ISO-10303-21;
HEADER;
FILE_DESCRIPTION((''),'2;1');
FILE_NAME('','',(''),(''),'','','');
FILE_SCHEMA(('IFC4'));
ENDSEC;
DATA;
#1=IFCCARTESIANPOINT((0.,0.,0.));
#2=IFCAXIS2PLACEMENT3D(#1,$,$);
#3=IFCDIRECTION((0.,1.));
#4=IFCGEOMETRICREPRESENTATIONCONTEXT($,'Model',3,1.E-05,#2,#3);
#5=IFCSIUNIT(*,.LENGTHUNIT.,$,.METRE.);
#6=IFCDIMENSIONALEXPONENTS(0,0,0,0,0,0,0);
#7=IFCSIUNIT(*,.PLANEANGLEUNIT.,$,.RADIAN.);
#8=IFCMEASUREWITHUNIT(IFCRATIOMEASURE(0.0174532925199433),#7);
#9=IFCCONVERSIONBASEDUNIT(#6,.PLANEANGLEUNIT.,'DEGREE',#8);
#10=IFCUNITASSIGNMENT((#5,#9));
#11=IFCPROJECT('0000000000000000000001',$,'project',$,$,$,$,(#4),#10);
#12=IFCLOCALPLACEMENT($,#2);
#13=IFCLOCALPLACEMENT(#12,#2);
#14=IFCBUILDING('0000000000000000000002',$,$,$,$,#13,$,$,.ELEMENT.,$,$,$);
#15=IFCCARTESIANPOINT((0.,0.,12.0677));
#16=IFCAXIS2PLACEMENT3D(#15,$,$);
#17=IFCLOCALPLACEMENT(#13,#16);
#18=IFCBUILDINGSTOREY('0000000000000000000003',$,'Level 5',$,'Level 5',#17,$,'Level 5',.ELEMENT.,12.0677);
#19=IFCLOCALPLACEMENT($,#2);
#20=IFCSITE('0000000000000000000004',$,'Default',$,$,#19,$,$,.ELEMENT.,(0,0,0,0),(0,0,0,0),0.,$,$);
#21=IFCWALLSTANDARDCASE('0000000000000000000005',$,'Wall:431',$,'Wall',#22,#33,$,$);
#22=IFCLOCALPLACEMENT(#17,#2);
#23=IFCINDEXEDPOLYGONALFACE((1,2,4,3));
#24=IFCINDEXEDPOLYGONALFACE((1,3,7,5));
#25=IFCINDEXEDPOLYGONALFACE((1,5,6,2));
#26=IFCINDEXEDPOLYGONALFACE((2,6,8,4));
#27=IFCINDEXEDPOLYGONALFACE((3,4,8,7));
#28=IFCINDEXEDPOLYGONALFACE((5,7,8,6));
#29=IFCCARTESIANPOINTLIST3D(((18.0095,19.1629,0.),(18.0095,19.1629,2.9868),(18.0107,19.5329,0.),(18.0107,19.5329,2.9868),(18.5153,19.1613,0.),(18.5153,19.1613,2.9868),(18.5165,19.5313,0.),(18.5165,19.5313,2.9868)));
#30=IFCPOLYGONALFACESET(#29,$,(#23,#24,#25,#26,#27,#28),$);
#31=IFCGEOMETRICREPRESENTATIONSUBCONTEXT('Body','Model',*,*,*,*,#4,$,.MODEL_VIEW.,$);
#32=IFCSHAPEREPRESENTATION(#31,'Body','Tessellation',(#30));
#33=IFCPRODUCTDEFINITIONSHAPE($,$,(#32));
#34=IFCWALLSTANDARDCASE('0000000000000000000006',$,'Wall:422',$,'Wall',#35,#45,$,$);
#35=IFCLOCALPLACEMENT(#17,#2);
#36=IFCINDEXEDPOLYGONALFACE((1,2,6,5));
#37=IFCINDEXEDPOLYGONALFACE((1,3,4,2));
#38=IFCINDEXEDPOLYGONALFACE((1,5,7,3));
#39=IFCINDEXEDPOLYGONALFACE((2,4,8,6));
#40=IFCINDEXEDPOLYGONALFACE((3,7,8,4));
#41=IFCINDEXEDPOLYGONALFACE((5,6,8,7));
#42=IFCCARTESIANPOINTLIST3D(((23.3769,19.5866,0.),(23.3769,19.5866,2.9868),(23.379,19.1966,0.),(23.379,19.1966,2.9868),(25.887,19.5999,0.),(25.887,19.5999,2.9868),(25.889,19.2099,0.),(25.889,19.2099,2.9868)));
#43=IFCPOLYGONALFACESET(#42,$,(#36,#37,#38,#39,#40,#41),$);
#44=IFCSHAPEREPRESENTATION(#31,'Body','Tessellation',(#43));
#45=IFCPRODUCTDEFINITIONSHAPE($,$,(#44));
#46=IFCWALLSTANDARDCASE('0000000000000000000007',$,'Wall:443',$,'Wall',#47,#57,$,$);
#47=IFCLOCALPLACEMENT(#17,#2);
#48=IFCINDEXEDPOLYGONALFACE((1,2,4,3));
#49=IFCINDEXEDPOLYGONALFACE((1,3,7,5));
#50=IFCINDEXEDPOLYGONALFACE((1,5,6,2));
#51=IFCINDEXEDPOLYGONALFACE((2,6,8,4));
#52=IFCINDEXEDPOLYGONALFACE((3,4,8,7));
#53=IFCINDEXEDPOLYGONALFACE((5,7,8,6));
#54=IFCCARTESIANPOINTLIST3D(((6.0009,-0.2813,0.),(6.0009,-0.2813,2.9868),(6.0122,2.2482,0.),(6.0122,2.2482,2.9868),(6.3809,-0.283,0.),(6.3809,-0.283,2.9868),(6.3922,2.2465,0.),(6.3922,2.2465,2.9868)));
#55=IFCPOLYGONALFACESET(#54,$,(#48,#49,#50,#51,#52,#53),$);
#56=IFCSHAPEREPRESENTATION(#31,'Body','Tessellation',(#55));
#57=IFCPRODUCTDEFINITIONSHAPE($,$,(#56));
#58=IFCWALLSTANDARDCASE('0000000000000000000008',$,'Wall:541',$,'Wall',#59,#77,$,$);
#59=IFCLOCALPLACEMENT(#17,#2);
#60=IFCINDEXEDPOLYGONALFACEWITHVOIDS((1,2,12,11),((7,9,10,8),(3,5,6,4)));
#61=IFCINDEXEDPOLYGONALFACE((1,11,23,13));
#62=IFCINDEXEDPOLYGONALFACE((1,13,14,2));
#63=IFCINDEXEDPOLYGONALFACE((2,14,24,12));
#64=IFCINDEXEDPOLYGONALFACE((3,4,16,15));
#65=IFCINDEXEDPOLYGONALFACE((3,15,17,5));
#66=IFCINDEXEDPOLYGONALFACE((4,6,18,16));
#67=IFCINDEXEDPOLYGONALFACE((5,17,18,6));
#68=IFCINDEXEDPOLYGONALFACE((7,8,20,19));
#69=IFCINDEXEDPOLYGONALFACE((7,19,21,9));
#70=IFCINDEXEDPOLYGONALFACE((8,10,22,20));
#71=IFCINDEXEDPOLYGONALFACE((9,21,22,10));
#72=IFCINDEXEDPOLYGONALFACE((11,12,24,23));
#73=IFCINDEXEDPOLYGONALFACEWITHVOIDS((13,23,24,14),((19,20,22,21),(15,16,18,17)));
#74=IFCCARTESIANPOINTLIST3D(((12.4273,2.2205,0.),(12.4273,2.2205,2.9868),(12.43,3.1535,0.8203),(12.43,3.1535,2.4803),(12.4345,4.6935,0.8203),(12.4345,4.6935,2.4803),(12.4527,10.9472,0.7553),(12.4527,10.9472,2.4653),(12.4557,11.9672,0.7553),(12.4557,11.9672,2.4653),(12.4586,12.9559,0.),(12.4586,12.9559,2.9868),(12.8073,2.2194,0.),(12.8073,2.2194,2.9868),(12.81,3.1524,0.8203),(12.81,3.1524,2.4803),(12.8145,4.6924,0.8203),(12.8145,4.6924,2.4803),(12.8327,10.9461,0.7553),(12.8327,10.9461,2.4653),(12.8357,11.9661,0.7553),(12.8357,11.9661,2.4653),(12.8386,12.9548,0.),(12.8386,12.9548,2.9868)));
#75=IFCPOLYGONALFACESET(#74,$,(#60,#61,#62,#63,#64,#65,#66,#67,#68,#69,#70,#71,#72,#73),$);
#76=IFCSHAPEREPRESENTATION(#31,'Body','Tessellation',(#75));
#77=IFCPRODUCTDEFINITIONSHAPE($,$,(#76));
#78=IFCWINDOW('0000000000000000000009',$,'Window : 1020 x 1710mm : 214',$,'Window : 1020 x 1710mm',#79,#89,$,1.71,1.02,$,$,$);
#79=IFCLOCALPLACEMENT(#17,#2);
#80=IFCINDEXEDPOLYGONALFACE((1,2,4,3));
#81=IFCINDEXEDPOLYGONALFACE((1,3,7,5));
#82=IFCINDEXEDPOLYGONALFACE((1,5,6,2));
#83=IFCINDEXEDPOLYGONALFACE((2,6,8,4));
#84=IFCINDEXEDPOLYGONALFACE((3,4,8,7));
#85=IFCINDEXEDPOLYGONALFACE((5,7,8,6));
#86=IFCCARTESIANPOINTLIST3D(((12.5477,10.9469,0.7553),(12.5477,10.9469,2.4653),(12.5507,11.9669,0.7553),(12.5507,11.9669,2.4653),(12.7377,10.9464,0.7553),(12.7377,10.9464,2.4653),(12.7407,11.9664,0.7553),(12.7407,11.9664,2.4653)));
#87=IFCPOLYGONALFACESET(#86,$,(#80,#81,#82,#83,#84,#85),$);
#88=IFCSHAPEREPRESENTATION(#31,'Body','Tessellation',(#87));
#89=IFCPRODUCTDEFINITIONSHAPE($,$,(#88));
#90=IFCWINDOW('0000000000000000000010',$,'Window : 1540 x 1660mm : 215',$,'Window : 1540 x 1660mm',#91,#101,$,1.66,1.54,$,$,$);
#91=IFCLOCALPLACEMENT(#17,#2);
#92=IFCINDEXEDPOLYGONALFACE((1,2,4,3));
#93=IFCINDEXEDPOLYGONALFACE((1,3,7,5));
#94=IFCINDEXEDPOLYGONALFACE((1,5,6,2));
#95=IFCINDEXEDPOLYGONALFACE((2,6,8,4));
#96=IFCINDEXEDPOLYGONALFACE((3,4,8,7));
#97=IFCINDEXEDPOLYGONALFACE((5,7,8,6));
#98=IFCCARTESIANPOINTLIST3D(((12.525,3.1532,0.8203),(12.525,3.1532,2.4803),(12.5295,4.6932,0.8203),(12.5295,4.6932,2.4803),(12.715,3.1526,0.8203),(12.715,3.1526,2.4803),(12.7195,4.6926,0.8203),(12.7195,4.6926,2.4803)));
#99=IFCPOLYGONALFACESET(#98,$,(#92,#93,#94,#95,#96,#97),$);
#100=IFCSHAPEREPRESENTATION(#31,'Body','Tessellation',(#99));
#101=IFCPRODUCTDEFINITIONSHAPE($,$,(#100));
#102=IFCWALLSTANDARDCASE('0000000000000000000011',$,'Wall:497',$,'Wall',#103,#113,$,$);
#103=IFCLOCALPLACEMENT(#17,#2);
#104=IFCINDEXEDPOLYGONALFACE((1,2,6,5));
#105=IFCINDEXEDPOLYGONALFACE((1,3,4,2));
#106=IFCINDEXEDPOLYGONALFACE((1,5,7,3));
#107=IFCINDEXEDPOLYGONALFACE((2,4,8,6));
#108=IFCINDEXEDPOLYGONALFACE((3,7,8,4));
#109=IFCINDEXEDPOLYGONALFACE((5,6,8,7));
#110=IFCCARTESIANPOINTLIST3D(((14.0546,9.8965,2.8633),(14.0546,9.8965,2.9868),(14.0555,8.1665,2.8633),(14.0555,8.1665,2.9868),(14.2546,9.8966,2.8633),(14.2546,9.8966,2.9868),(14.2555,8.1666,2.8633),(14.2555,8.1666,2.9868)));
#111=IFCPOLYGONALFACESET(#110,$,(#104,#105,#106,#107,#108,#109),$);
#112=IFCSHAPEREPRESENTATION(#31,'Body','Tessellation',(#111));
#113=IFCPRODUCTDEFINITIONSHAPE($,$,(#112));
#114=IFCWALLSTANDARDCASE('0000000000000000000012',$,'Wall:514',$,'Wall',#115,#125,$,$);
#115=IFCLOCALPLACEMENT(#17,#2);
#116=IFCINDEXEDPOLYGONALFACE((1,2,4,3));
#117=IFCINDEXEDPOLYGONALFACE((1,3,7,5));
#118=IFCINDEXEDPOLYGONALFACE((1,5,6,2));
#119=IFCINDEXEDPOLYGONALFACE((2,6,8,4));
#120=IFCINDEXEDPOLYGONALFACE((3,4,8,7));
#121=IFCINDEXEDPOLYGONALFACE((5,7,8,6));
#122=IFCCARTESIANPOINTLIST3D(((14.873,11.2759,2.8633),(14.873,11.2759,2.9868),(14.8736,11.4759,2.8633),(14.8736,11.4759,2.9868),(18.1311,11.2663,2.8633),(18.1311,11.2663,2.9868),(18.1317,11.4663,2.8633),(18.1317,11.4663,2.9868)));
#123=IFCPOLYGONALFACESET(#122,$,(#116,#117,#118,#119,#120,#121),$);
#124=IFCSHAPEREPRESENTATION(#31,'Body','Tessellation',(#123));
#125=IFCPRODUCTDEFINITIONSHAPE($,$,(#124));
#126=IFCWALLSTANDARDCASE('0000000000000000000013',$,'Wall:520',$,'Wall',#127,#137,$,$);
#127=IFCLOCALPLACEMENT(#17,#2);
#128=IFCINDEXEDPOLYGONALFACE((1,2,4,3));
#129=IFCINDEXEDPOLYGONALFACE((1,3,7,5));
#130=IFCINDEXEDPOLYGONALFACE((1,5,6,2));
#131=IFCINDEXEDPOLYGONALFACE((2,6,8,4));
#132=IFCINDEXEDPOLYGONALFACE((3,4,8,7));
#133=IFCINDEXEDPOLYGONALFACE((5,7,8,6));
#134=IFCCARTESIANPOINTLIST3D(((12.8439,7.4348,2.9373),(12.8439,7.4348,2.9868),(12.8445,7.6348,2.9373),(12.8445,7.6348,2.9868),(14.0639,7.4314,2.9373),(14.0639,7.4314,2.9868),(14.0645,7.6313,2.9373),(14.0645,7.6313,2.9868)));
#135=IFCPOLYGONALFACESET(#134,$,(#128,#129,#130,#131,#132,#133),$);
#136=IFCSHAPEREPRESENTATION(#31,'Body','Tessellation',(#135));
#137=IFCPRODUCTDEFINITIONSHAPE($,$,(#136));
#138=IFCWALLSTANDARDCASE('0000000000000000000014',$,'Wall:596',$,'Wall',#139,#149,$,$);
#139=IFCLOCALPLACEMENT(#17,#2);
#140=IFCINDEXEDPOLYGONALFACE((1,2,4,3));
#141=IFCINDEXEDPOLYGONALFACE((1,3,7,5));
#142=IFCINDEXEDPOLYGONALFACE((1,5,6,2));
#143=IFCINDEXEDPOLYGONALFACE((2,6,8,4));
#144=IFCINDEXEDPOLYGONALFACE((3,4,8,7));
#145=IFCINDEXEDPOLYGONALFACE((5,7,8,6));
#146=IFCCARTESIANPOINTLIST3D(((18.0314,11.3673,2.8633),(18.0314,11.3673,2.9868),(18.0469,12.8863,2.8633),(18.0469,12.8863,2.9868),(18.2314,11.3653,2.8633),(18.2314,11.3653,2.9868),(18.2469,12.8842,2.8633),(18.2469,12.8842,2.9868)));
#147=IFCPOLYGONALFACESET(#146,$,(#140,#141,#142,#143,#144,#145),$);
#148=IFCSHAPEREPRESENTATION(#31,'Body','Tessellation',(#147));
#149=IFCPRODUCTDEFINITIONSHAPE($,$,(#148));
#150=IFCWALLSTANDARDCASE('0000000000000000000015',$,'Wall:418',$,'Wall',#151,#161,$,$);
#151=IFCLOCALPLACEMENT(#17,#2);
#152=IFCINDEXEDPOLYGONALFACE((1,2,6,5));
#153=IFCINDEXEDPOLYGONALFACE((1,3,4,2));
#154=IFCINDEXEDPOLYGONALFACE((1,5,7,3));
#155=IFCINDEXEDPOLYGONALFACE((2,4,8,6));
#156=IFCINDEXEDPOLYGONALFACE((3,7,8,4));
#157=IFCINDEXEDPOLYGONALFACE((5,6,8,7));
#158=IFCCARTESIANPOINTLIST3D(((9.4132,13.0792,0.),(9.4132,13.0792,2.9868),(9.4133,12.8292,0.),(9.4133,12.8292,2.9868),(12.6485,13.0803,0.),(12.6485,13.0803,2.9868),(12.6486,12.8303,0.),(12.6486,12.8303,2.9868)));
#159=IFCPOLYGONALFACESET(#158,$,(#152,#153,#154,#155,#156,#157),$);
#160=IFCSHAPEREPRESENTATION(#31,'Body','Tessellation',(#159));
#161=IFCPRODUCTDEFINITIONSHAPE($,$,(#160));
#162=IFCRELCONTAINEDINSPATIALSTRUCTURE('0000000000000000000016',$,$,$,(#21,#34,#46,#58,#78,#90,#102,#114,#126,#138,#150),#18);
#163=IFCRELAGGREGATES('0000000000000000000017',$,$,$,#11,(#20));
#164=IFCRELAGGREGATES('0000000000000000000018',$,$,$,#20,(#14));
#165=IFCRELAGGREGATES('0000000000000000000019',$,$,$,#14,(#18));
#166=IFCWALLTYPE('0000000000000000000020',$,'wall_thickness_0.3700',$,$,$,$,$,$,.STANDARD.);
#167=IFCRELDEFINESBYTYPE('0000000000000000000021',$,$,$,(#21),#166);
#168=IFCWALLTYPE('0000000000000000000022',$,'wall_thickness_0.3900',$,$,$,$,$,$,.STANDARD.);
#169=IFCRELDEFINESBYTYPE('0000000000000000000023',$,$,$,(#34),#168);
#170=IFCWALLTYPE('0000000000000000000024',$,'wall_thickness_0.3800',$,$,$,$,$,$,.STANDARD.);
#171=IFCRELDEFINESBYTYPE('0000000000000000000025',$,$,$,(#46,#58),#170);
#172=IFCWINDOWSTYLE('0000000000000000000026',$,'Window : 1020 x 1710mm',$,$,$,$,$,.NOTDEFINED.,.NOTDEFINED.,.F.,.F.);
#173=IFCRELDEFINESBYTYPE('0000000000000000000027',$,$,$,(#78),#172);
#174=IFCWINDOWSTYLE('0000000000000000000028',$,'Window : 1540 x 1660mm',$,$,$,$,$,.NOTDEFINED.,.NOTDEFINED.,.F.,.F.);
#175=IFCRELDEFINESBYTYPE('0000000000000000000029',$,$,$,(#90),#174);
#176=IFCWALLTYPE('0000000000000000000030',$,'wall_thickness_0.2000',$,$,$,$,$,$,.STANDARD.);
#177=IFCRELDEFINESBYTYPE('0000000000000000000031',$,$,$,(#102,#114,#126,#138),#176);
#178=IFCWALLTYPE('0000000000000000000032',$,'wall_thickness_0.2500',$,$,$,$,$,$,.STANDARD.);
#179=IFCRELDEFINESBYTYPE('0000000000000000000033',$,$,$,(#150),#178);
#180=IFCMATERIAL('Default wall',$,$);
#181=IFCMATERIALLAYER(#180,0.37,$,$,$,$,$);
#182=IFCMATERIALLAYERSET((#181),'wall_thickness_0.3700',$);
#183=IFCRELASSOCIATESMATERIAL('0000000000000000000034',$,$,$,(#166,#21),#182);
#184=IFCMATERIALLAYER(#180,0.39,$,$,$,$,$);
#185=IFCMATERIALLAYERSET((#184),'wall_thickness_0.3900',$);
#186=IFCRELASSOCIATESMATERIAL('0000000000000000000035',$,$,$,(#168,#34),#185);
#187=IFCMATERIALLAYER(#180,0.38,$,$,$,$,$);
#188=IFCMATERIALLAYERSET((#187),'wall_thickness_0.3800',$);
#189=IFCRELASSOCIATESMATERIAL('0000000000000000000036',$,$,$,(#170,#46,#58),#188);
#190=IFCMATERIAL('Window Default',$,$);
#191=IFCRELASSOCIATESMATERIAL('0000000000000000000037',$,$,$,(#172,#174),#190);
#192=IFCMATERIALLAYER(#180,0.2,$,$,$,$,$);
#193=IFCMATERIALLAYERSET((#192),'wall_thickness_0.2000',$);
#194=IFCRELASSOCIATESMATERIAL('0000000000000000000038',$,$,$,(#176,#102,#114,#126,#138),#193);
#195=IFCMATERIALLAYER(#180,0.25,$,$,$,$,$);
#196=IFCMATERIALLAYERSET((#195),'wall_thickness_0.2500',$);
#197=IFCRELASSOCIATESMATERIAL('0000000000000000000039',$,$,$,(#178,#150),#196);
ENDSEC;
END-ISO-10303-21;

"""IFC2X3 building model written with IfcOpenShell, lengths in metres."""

from ifc_helpers import new_model, entity, si_unit, converted_unit, direction, frame, frame_2d, origin, origin_2d_with_axis, place, context, subcontext, project, spatial, polyline, rectangle, outline, extrude, source, transform, mapped, material, layer, layer_set, layer_usage, type_object, type_shapes, element, fill, save


model = new_model("IFC2X3")

# Units and contexts
model_context = context("Model", 3, precision=1e-05, world=origin(), true_north=direction((0.0, 1.0)))
body_context = subcontext(model_context, "Body", "Model", "MODEL_VIEW")
ifc_project = project(units=[si_unit("LENGTHUNIT", "METRE"), converted_unit("PLANEANGLEUNIT", "DEGREE", entity("IfcRatioMeasure", 0.0174532925199433), si_unit("PLANEANGLEUNIT", "RADIAN"), dimensions=[0, 0, 0, 0, 0, 0, 0])], contexts=[model_context])

# Site, building, storey
site_placement = place(None, origin())
site = spatial("IfcSite", under=ifc_project, at=site_placement, Name="Default", CompositionType="ELEMENT", RefLatitude=(0, 0, 0, 0), RefLongitude=(0, 0, 0, 0), RefElevation=0.0)
placement_1 = place(None, origin())
building_placement = place(placement_1, origin())
building = spatial("IfcBuilding", under=site, at=building_placement, CompositionType="ELEMENT")
storey_placement = place(building_placement, frame((0.0, 0.0, 12.0677)))
storey = spatial("IfcBuildingStorey", under=building, at=storey_placement, Name="Level 5", ObjectType="Level 5", LongName="Level 5", CompositionType="ELEMENT", Elevation=12.0677)

# Walls
ifc_material_1 = material(Name="Default wall")
ifc_layer_1 = layer(ifc_material_1, 0.37)
ifc_layer_set_1 = layer_set([ifc_layer_1], Name="wall_thickness_0.3700")
ifc_layer_usage_1 = layer_usage(ifc_layer_set_1, "AXIS2", "POSITIVE", -0.185)
wall_type_1 = type_object("IfcWallType", Name="wall_thickness_0.3700", PredefinedType="STANDARD", material=ifc_layer_set_1)
wall_1_placement = place(storey_placement, frame((18.0101, 19.3479, 0.0), z_axis=(0.0, 0.0, 1.0), x_axis=(0.999995, -0.003224, 0.0)))
element("IfcWallStandardCase", 1, at=wall_1_placement, inside=storey, type_object=wall_type_1, material=ifc_layer_usage_1, Name="Wall:431", ObjectType="Wall", context=body_context, shape_type="SweptSolid", body=[
    extrude(outline(polyline([(0.5058, -0.185), (0.5058, 0.185), (0.0, 0.185), (0.0, -0.185), (0.5058, -0.185)])), origin(), (0.0, 0.0, 1.0), 2.9868),
])
ifc_layer_2 = layer(ifc_material_1, 0.39)
ifc_layer_set_2 = layer_set([ifc_layer_2], Name="wall_thickness_0.3900")
ifc_layer_usage_2 = layer_usage(ifc_layer_set_2, "AXIS2", "POSITIVE", -0.195)
wall_type_2 = type_object("IfcWallType", Name="wall_thickness_0.3900", PredefinedType="STANDARD", material=ifc_layer_set_2)
wall_2_placement = place(storey_placement, frame((23.3779, 19.3916, 0.0), z_axis=(0.0, 0.0, 1.0), x_axis=(0.999986, 0.0053, 0.0)))
element("IfcWallStandardCase", 2, at=wall_2_placement, inside=storey, type_object=wall_type_2, material=ifc_layer_usage_2, Name="Wall:422", ObjectType="Wall", context=body_context, shape_type="SweptSolid", body=[
    extrude(outline(polyline([(2.5101, -0.195), (2.5101, 0.195), (0.0, 0.195), (0.0, -0.195), (2.5101, -0.195)])), origin(), (0.0, 0.0, 1.0), 2.9868),
])
ifc_layer_3 = layer(ifc_material_1, 0.38)
ifc_layer_set_3 = layer_set([ifc_layer_3], Name="wall_thickness_0.3800")
ifc_layer_usage_3 = layer_usage(ifc_layer_set_3, "AXIS2", "POSITIVE", -0.19)
wall_type_3 = type_object("IfcWallType", Name="wall_thickness_0.3800", PredefinedType="STANDARD", material=ifc_layer_set_3)
wall_3_placement = place(storey_placement, frame((6.2022, 2.2474, 0.0), z_axis=(0.0, 0.0, 1.0), x_axis=(-0.004469, -0.99999, 0.0)))
element("IfcWallStandardCase", 3, at=wall_3_placement, inside=storey, type_object=wall_type_3, material=ifc_layer_usage_3, Name="Wall:443", ObjectType="Wall", context=body_context, shape_type="SweptSolid", body=[
    extrude(outline(polyline([(2.5295, -0.19), (2.5295, 0.19), (0.0, 0.19), (0.0, -0.19), (2.5295, -0.19)])), origin(), (0.0, 0.0, 1.0), 2.9868),
])

# Wall, openings, windows
wall_4_placement = place(storey_placement, frame((12.6486, 12.9553, 0.0), z_axis=(0.0, 0.0, 1.0), x_axis=(-0.00291, -0.999996, 0.0)))
wall_4 = element("IfcWallStandardCase", 4, at=wall_4_placement, inside=storey, type_object=wall_type_3, material=ifc_layer_usage_3, Name="Wall:541", ObjectType="Wall", context=body_context, shape_type="SweptSolid", body=[
    extrude(outline(polyline([(10.7355, -0.19), (10.7355, 0.19), (0.0, 0.19), (0.0, -0.19), (10.7355, -0.19)])), origin(), (0.0, 0.0, 1.0), 2.9868),
])
opening_1_placement = place(wall_4_placement, frame((0.9887, -0.19, 0.7553)))
opening_1 = element("IfcOpeningElement", 5, at=opening_1_placement, cuts=wall_4, ObjectType="Opening", context=body_context, shape_type="SweptSolid", body=[
    extrude(rectangle(XDim=1.02, YDim=1.71, at=frame_2d((0.855, 0.51), x_axis=(0.0, 1.0))), frame((0.0, 0.0, 0.0), z_axis=(0.0, 1.0, 0.0), x_axis=(0.0, 0.0, 1.0)), (0.0, 0.0, 1.0), 0.38),
])
opening_2_placement = place(wall_4_placement, frame((8.2625, -0.19, 0.8203)))
opening_2 = element("IfcOpeningElement", 6, at=opening_2_placement, cuts=wall_4, ObjectType="Opening", context=body_context, shape_type="SweptSolid", body=[
    extrude(rectangle(XDim=1.54, YDim=1.66, at=frame_2d((0.83, 0.77), x_axis=(0.0, 1.0))), frame((0.0, 0.0, 0.0), z_axis=(0.0, 1.0, 0.0), x_axis=(0.0, 0.0, 1.0)), (0.0, 0.0, 1.0), 0.38),
])
ifc_material_2 = material(Name="Window Default")
window_style_1 = type_object("IfcWindowStyle", Name="Window : 1020 x 1710mm", ConstructionType="NOTDEFINED", OperationType="NOTDEFINED", ParameterTakesPrecedence=False, Sizeable=False, material=ifc_material_2)
shared_shape_1 = source(origin(), body_context, "Body", "SweptSolid", [
    extrude(rectangle(XDim=0.19, YDim=1.02, at=origin_2d_with_axis()), frame((0.51, 0.19, 0.0), z_axis=(0.0, 0.0, 1.0), x_axis=(0.0, 1.0, 0.0)), (0.0, 0.0, 1.0), 1.71),
])
type_shapes(window_style_1, [shared_shape_1])
window_1_placement = place(opening_1_placement, origin())
window_1 = element("IfcWindow", 7, at=window_1_placement, inside=storey, type_object=window_style_1, Name="Window : 1020 x 1710mm : 214", ObjectType="Window : 1020 x 1710mm", OverallHeight=1.71, OverallWidth=1.02, context=body_context, shape_type="MappedRepresentation", body=[
    mapped(shared_shape_1, transform((0.0, 0.0, 0.0), scale=1.0)),
])
fill(opening_1, window_1)
window_style_2 = type_object("IfcWindowStyle", Name="Window : 1540 x 1660mm", ConstructionType="NOTDEFINED", OperationType="NOTDEFINED", ParameterTakesPrecedence=False, Sizeable=False, material=ifc_material_2)
shared_shape_2 = source(origin(), body_context, "Body", "SweptSolid", [
    extrude(rectangle(XDim=0.19, YDim=1.54, at=origin_2d_with_axis()), frame((0.77, 0.19, 0.0), z_axis=(0.0, 0.0, 1.0), x_axis=(0.0, 1.0, 0.0)), (0.0, 0.0, 1.0), 1.66),
])
type_shapes(window_style_2, [shared_shape_2])
window_2_placement = place(opening_2_placement, origin())
window_2 = element("IfcWindow", 8, at=window_2_placement, inside=storey, type_object=window_style_2, Name="Window : 1540 x 1660mm : 215", ObjectType="Window : 1540 x 1660mm", OverallHeight=1.66, OverallWidth=1.54, context=body_context, shape_type="MappedRepresentation", body=[
    mapped(shared_shape_2, transform((0.0, 0.0, 0.0), scale=1.0)),
])
fill(opening_2, window_2)

# Walls
ifc_layer_4 = layer(ifc_material_1, 0.2)
ifc_layer_set_4 = layer_set([ifc_layer_4], Name="wall_thickness_0.2000")
ifc_layer_usage_4 = layer_usage(ifc_layer_set_4, "AXIS2", "POSITIVE", -0.1)
wall_type_4 = type_object("IfcWallType", Name="wall_thickness_0.2000", PredefinedType="STANDARD", material=ifc_layer_set_4)
placement_2 = place(building_placement, frame((0.0, 0.0, 14.931)))
wall_5_placement = place(placement_2, frame((14.1555, 8.1666, 0.0), z_axis=(0.0, 0.0, 1.0), x_axis=(-0.000537, 1.0, 0.0)))
element("IfcWallStandardCase", 9, at=wall_5_placement, inside=storey, type_object=wall_type_4, material=ifc_layer_usage_4, Name="Wall:497", ObjectType="Wall", context=body_context, shape_type="SweptSolid", body=[
    extrude(outline(polyline([(1.73, -0.1), (1.73, 0.1), (0.0, 0.1), (0.0, -0.1), (1.73, -0.1)])), origin(), (0.0, 0.0, 1.0), 0.1235),
])
placement_3 = place(building_placement, frame((0.0, 0.0, 14.931)))
wall_6_placement = place(placement_3, frame((14.8733, 11.3759, 0.0), z_axis=(0.0, 0.0, 1.0), x_axis=(0.999996, -0.00294, 0.0)))
element("IfcWallStandardCase", 10, at=wall_6_placement, inside=storey, type_object=wall_type_4, material=ifc_layer_usage_4, Name="Wall:514", ObjectType="Wall", context=body_context, shape_type="SweptSolid", body=[
    extrude(outline(polyline([(3.2581, -0.1), (3.2581, 0.1), (0.0, 0.1), (0.0, -0.1), (3.2581, -0.1)])), origin(), (0.0, 0.0, 1.0), 0.1235),
])
placement_4 = place(building_placement, frame((0.0, 0.0, 15.005)))
wall_7_placement = place(placement_4, frame((12.8442, 7.5348, 0.0), z_axis=(0.0, 0.0, 1.0), x_axis=(0.999996, -0.00285, 0.0)))
element("IfcWallStandardCase", 11, at=wall_7_placement, inside=storey, type_object=wall_type_4, material=ifc_layer_usage_4, Name="Wall:520", ObjectType="Wall", context=body_context, shape_type="SweptSolid", body=[
    extrude(outline(polyline([(1.22, -0.1), (1.22, 0.1), (0.0, 0.1), (0.0, -0.1), (1.22, -0.1)])), origin(), (0.0, 0.0, 1.0), 0.0495),
])
placement_5 = place(building_placement, frame((0.0, 0.0, 14.931)))
wall_8_placement = place(placement_5, frame((18.1314, 11.3663, 0.0), z_axis=(0.0, 0.0, 1.0), x_axis=(0.010224, 0.999948, 0.0)))
element("IfcWallStandardCase", 12, at=wall_8_placement, inside=storey, type_object=wall_type_4, material=ifc_layer_usage_4, Name="Wall:596", ObjectType="Wall", context=body_context, shape_type="SweptSolid", body=[
    extrude(outline(polyline([(1.5191, -0.1), (1.5191, 0.1), (0.0, 0.1), (0.0, -0.1), (1.5191, -0.1)])), origin(), (0.0, 0.0, 1.0), 0.1235),
])
ifc_layer_5 = layer(ifc_material_1, 0.25)
ifc_layer_set_5 = layer_set([ifc_layer_5], Name="wall_thickness_0.2500")
ifc_layer_usage_5 = layer_usage(ifc_layer_set_5, "AXIS2", "POSITIVE", -0.125)
wall_type_5 = type_object("IfcWallType", Name="wall_thickness_0.2500", PredefinedType="STANDARD", material=ifc_layer_set_5)
wall_9_placement = place(storey_placement, frame((9.4133, 12.9542, 0.0), z_axis=(0.0, 0.0, 1.0), x_axis=(1.0, 0.000352, 0.0)))
element("IfcWallStandardCase", 13, at=wall_9_placement, inside=storey, type_object=wall_type_5, material=ifc_layer_usage_5, Name="Wall:418", ObjectType="Wall", context=body_context, shape_type="SweptSolid", body=[
    extrude(outline(polyline([(3.2353, -0.125), (3.2353, 0.125), (0.0, 0.125), (0.0, -0.125), (3.2353, -0.125)])), origin(), (0.0, 0.0, 1.0), 2.9868),
])

save(model, "model.ifc")
